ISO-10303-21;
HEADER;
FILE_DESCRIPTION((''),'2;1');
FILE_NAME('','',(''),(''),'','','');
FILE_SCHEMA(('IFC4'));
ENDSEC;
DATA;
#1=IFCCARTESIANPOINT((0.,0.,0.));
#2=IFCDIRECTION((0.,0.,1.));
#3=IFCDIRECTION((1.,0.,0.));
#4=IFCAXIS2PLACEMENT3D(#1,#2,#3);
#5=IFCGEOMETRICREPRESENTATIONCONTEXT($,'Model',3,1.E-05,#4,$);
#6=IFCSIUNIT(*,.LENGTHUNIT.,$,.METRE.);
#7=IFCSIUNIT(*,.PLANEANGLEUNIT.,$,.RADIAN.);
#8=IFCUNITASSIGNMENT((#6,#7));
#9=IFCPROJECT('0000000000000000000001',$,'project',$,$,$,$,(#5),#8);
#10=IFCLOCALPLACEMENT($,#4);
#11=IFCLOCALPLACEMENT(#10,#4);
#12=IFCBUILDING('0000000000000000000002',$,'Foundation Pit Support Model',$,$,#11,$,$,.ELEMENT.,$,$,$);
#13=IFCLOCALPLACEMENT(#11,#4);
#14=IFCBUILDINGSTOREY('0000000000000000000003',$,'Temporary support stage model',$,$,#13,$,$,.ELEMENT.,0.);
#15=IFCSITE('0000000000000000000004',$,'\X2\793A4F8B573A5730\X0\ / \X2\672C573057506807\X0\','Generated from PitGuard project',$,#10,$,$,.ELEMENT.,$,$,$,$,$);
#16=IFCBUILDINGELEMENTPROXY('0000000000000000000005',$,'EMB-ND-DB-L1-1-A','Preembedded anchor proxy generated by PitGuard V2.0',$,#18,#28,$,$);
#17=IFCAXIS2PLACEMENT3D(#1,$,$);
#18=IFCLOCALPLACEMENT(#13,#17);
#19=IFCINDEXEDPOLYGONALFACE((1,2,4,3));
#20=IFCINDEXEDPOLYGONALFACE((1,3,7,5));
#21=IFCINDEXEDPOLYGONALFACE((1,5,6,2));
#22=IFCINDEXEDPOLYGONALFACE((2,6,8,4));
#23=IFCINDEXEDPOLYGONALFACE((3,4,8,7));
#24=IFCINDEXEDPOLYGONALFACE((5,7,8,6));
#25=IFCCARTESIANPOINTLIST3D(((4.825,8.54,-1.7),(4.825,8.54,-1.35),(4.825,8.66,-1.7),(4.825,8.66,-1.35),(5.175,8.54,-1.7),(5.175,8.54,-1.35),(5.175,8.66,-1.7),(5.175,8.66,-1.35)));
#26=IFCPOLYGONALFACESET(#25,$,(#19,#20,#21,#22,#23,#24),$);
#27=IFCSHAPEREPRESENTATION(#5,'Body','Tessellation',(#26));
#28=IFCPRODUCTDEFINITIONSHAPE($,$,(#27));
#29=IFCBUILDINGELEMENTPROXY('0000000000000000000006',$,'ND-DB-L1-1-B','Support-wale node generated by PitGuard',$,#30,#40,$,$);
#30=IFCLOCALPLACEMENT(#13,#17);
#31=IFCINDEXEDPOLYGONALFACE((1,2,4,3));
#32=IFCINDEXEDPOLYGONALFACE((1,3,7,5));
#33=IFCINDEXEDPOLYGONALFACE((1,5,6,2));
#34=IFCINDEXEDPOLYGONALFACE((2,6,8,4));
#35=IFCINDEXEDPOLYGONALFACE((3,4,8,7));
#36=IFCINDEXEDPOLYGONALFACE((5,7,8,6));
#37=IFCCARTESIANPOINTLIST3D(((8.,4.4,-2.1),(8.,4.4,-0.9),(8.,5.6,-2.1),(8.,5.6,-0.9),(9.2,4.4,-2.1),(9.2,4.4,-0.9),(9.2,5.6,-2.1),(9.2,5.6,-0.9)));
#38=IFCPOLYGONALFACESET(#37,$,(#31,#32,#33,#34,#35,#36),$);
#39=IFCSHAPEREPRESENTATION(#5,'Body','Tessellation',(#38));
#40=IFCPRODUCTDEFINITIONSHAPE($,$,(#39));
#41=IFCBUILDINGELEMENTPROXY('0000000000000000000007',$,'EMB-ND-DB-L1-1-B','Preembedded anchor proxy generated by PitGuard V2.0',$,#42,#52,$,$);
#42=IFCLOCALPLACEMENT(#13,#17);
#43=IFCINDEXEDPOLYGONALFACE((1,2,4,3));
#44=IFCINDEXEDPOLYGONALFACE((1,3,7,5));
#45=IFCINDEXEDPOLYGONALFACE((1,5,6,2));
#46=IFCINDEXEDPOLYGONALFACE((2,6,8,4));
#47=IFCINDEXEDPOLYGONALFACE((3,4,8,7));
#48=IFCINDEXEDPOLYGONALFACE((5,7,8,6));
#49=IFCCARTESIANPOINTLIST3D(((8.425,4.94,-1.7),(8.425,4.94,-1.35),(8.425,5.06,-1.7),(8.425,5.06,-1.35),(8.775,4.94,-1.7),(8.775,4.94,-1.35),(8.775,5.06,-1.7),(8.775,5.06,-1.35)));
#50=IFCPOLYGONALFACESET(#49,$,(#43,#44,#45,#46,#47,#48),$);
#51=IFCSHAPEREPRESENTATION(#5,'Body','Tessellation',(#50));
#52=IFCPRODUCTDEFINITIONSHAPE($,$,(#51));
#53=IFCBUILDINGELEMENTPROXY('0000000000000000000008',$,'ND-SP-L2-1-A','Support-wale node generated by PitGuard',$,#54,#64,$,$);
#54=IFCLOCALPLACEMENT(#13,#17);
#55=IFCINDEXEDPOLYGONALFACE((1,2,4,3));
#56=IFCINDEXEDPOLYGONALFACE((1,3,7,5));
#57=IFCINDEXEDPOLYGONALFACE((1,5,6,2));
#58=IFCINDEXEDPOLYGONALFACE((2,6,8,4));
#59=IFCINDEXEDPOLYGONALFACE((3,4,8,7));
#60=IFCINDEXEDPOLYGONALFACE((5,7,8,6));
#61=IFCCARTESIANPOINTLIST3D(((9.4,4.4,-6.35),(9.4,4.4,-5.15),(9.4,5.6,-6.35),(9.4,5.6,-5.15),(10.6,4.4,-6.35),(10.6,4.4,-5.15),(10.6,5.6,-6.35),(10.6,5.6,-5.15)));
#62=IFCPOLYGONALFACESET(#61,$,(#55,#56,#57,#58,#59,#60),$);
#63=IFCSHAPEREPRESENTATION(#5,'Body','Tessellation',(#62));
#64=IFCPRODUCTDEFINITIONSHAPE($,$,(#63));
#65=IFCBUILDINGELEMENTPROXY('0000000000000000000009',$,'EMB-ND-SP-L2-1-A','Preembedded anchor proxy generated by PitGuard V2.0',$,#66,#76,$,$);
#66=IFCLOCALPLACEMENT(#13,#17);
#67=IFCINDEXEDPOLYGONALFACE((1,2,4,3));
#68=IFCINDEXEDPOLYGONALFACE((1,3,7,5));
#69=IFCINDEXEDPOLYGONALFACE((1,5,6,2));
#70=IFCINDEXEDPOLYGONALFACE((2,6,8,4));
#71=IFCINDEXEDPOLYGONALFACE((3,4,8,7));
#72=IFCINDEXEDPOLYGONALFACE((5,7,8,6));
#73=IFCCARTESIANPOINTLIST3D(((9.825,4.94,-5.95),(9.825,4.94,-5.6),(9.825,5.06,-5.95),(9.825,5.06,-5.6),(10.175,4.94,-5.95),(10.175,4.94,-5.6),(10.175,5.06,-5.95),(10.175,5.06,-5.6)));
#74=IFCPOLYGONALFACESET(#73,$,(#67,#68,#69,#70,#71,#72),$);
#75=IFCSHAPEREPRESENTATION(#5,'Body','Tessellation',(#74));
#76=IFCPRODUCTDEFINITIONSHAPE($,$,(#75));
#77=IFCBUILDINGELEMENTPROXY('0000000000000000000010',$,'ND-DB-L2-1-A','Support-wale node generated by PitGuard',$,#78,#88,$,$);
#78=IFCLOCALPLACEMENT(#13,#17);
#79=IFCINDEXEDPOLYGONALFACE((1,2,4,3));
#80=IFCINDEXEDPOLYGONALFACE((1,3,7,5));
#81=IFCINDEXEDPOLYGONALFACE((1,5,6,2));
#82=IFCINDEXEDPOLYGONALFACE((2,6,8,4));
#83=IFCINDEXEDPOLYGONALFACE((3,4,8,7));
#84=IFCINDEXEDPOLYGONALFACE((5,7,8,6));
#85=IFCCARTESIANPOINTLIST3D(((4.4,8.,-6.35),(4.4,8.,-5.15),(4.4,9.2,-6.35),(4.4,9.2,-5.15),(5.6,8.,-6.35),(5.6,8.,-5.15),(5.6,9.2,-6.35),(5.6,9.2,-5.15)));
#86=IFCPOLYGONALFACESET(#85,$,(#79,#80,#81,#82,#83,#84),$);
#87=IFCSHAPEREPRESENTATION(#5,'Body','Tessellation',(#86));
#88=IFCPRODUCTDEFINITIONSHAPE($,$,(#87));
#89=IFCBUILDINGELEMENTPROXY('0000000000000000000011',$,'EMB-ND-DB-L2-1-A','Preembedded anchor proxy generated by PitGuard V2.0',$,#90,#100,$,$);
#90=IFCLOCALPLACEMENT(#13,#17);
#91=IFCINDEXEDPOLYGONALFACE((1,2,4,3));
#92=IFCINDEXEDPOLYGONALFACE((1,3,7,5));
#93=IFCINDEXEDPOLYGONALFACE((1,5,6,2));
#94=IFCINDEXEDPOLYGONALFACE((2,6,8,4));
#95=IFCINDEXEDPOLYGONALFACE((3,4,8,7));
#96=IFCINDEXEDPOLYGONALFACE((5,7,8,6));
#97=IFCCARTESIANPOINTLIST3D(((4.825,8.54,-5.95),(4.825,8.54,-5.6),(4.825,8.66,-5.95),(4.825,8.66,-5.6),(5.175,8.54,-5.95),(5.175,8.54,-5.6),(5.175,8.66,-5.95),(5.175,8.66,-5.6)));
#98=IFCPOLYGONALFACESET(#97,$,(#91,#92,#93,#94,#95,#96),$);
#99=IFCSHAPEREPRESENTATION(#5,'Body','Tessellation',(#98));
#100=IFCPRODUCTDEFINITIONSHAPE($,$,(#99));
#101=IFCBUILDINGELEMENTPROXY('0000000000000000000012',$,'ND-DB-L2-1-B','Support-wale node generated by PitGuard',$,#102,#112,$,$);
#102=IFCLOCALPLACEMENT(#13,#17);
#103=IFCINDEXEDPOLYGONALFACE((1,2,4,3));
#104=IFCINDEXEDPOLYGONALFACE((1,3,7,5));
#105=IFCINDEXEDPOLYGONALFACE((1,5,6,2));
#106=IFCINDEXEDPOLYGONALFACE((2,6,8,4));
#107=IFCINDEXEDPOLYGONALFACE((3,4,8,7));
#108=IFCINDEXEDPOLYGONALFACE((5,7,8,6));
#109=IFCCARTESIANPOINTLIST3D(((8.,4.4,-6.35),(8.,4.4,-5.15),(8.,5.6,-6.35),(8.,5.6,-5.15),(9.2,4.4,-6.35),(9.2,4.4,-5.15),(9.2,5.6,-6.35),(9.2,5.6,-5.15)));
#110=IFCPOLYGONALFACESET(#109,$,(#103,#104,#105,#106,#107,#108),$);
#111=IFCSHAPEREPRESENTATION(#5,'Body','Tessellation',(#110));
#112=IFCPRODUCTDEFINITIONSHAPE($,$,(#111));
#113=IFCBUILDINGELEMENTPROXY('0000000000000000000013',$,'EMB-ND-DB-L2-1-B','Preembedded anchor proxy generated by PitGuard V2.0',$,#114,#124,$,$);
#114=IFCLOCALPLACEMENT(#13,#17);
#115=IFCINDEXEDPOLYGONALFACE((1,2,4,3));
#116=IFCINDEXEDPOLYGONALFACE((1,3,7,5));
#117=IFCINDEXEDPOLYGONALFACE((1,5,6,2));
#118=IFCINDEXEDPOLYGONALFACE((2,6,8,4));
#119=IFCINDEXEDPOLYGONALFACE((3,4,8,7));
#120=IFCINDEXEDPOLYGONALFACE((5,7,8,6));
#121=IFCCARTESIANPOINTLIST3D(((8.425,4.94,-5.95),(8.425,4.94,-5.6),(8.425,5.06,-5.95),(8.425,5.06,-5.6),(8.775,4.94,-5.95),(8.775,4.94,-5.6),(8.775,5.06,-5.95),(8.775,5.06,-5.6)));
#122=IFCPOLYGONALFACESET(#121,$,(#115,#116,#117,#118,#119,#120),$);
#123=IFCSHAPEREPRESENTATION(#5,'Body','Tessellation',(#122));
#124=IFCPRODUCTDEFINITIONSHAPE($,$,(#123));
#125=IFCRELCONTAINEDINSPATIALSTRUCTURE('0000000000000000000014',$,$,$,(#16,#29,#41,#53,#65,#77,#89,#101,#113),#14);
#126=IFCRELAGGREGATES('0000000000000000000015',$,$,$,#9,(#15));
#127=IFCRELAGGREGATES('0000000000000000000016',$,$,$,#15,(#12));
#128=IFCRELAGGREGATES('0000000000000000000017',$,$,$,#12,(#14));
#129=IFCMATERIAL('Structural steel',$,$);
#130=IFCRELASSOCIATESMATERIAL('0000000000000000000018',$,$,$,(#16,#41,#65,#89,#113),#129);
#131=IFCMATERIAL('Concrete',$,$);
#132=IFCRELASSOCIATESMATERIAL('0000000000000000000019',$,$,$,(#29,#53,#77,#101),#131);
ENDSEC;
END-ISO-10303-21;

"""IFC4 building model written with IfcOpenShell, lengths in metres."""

from ifc_helpers import new_model, si_unit, frame, origin_with_axes, origin_2d, place, context, project, spatial, rectangle, extrude, material, element, save


model = new_model("IFC4")

# Units and contexts
model_context = context("Model", 3, precision=1e-05, world=origin_with_axes())
ifc_project = project(units=[si_unit("LENGTHUNIT", "METRE"), si_unit("PLANEANGLEUNIT", "RADIAN")], contexts=[model_context])

# Site, building, storey
site_placement = place(None, origin_with_axes())
site = spatial("IfcSite", under=ifc_project, at=site_placement, Name="示例场地 / 本地坐标", Description="Generated from PitGuard project", CompositionType="ELEMENT")
building_placement = place(site_placement, origin_with_axes())
building = spatial("IfcBuilding", under=site, at=building_placement, Name="Foundation Pit Support Model", CompositionType="ELEMENT")
storey_placement = place(building_placement, origin_with_axes())
storey = spatial("IfcBuildingStorey", under=building, at=storey_placement, Name="Temporary support stage model", CompositionType="ELEMENT", Elevation=0.0)

# Shared definitions
ifc_material_1 = material(Name="Concrete")

# Shared definitions
ifc_material_2 = material(Name="Structural steel")

# Building element proxies
proxy_1_placement = place(storey_placement, frame((5.0, 8.6, -1.7), z_axis=(0.0, 0.0, 1.0), x_axis=(1.0, 0.0, 0.0)))
element("IfcBuildingElementProxy", 1, at=proxy_1_placement, inside=storey, material=ifc_material_2, Name="EMB-ND-DB-L1-1-A", Description="Preembedded anchor proxy generated by PitGuard V2.0", context=model_context, shape_type="SweptSolid", body=[
    extrude(rectangle(XDim=0.35, YDim=0.12, at=origin_2d()), origin_with_axes(), (0.0, 0.0, 1.0), 0.35),
])
proxy_2_placement = place(storey_placement, frame((8.6, 5.0, -2.1), z_axis=(0.0, 0.0, 1.0), x_axis=(1.0, 0.0, 0.0)))
element("IfcBuildingElementProxy", 2, at=proxy_2_placement, inside=storey, material=ifc_material_1, Name="ND-DB-L1-1-B", Description="Support-wale node generated by PitGuard", context=model_context, shape_type="SweptSolid", body=[
    extrude(rectangle(XDim=1.2, YDim=1.2, at=origin_2d()), origin_with_axes(), (0.0, 0.0, 1.0), 1.2),
])
proxy_3_placement = place(storey_placement, frame((8.6, 5.0, -1.7), z_axis=(0.0, 0.0, 1.0), x_axis=(1.0, 0.0, 0.0)))
element("IfcBuildingElementProxy", 3, at=proxy_3_placement, inside=storey, material=ifc_material_2, Name="EMB-ND-DB-L1-1-B", Description="Preembedded anchor proxy generated by PitGuard V2.0", context=model_context, shape_type="SweptSolid", body=[
    extrude(rectangle(XDim=0.35, YDim=0.12, at=origin_2d()), origin_with_axes(), (0.0, 0.0, 1.0), 0.35),
])
proxy_4_placement = place(storey_placement, frame((10.0, 5.0, -6.35), z_axis=(0.0, 0.0, 1.0), x_axis=(1.0, 0.0, 0.0)))
element("IfcBuildingElementProxy", 4, at=proxy_4_placement, inside=storey, material=ifc_material_1, Name="ND-SP-L2-1-A", Description="Support-wale node generated by PitGuard", context=model_context, shape_type="SweptSolid", body=[
    extrude(rectangle(XDim=1.2, YDim=1.2, at=origin_2d()), origin_with_axes(), (0.0, 0.0, 1.0), 1.2),
])
proxy_5_placement = place(storey_placement, frame((10.0, 5.0, -5.95), z_axis=(0.0, 0.0, 1.0), x_axis=(1.0, 0.0, 0.0)))
element("IfcBuildingElementProxy", 5, at=proxy_5_placement, inside=storey, material=ifc_material_2, Name="EMB-ND-SP-L2-1-A", Description="Preembedded anchor proxy generated by PitGuard V2.0", context=model_context, shape_type="SweptSolid", body=[
    extrude(rectangle(XDim=0.35, YDim=0.12, at=origin_2d()), origin_with_axes(), (0.0, 0.0, 1.0), 0.35),
])
proxy_6_placement = place(storey_placement, frame((5.0, 8.6, -6.35), z_axis=(0.0, 0.0, 1.0), x_axis=(1.0, 0.0, 0.0)))
element("IfcBuildingElementProxy", 6, at=proxy_6_placement, inside=storey, material=ifc_material_1, Name="ND-DB-L2-1-A", Description="Support-wale node generated by PitGuard", context=model_context, shape_type="SweptSolid", body=[
    extrude(rectangle(XDim=1.2, YDim=1.2, at=origin_2d()), origin_with_axes(), (0.0, 0.0, 1.0), 1.2),
])
proxy_7_placement = place(storey_placement, frame((5.0, 8.6, -5.95), z_axis=(0.0, 0.0, 1.0), x_axis=(1.0, 0.0, 0.0)))
element("IfcBuildingElementProxy", 7, at=proxy_7_placement, inside=storey, material=ifc_material_2, Name="EMB-ND-DB-L2-1-A", Description="Preembedded anchor proxy generated by PitGuard V2.0", context=model_context, shape_type="SweptSolid", body=[
    extrude(rectangle(XDim=0.35, YDim=0.12, at=origin_2d()), origin_with_axes(), (0.0, 0.0, 1.0), 0.35),
])
proxy_8_placement = place(storey_placement, frame((8.6, 5.0, -6.35), z_axis=(0.0, 0.0, 1.0), x_axis=(1.0, 0.0, 0.0)))
element("IfcBuildingElementProxy", 8, at=proxy_8_placement, inside=storey, material=ifc_material_1, Name="ND-DB-L2-1-B", Description="Support-wale node generated by PitGuard", context=model_context, shape_type="SweptSolid", body=[
    extrude(rectangle(XDim=1.2, YDim=1.2, at=origin_2d()), origin_with_axes(), (0.0, 0.0, 1.0), 1.2),
])
proxy_9_placement = place(storey_placement, frame((8.6, 5.0, -5.95), z_axis=(0.0, 0.0, 1.0), x_axis=(1.0, 0.0, 0.0)))
element("IfcBuildingElementProxy", 9, at=proxy_9_placement, inside=storey, material=ifc_material_2, Name="EMB-ND-DB-L2-1-B", Description="Preembedded anchor proxy generated by PitGuard V2.0", context=model_context, shape_type="SweptSolid", body=[
    extrude(rectangle(XDim=0.35, YDim=0.12, at=origin_2d()), origin_with_axes(), (0.0, 0.0, 1.0), 0.35),
])

save(model, "model.ifc")
